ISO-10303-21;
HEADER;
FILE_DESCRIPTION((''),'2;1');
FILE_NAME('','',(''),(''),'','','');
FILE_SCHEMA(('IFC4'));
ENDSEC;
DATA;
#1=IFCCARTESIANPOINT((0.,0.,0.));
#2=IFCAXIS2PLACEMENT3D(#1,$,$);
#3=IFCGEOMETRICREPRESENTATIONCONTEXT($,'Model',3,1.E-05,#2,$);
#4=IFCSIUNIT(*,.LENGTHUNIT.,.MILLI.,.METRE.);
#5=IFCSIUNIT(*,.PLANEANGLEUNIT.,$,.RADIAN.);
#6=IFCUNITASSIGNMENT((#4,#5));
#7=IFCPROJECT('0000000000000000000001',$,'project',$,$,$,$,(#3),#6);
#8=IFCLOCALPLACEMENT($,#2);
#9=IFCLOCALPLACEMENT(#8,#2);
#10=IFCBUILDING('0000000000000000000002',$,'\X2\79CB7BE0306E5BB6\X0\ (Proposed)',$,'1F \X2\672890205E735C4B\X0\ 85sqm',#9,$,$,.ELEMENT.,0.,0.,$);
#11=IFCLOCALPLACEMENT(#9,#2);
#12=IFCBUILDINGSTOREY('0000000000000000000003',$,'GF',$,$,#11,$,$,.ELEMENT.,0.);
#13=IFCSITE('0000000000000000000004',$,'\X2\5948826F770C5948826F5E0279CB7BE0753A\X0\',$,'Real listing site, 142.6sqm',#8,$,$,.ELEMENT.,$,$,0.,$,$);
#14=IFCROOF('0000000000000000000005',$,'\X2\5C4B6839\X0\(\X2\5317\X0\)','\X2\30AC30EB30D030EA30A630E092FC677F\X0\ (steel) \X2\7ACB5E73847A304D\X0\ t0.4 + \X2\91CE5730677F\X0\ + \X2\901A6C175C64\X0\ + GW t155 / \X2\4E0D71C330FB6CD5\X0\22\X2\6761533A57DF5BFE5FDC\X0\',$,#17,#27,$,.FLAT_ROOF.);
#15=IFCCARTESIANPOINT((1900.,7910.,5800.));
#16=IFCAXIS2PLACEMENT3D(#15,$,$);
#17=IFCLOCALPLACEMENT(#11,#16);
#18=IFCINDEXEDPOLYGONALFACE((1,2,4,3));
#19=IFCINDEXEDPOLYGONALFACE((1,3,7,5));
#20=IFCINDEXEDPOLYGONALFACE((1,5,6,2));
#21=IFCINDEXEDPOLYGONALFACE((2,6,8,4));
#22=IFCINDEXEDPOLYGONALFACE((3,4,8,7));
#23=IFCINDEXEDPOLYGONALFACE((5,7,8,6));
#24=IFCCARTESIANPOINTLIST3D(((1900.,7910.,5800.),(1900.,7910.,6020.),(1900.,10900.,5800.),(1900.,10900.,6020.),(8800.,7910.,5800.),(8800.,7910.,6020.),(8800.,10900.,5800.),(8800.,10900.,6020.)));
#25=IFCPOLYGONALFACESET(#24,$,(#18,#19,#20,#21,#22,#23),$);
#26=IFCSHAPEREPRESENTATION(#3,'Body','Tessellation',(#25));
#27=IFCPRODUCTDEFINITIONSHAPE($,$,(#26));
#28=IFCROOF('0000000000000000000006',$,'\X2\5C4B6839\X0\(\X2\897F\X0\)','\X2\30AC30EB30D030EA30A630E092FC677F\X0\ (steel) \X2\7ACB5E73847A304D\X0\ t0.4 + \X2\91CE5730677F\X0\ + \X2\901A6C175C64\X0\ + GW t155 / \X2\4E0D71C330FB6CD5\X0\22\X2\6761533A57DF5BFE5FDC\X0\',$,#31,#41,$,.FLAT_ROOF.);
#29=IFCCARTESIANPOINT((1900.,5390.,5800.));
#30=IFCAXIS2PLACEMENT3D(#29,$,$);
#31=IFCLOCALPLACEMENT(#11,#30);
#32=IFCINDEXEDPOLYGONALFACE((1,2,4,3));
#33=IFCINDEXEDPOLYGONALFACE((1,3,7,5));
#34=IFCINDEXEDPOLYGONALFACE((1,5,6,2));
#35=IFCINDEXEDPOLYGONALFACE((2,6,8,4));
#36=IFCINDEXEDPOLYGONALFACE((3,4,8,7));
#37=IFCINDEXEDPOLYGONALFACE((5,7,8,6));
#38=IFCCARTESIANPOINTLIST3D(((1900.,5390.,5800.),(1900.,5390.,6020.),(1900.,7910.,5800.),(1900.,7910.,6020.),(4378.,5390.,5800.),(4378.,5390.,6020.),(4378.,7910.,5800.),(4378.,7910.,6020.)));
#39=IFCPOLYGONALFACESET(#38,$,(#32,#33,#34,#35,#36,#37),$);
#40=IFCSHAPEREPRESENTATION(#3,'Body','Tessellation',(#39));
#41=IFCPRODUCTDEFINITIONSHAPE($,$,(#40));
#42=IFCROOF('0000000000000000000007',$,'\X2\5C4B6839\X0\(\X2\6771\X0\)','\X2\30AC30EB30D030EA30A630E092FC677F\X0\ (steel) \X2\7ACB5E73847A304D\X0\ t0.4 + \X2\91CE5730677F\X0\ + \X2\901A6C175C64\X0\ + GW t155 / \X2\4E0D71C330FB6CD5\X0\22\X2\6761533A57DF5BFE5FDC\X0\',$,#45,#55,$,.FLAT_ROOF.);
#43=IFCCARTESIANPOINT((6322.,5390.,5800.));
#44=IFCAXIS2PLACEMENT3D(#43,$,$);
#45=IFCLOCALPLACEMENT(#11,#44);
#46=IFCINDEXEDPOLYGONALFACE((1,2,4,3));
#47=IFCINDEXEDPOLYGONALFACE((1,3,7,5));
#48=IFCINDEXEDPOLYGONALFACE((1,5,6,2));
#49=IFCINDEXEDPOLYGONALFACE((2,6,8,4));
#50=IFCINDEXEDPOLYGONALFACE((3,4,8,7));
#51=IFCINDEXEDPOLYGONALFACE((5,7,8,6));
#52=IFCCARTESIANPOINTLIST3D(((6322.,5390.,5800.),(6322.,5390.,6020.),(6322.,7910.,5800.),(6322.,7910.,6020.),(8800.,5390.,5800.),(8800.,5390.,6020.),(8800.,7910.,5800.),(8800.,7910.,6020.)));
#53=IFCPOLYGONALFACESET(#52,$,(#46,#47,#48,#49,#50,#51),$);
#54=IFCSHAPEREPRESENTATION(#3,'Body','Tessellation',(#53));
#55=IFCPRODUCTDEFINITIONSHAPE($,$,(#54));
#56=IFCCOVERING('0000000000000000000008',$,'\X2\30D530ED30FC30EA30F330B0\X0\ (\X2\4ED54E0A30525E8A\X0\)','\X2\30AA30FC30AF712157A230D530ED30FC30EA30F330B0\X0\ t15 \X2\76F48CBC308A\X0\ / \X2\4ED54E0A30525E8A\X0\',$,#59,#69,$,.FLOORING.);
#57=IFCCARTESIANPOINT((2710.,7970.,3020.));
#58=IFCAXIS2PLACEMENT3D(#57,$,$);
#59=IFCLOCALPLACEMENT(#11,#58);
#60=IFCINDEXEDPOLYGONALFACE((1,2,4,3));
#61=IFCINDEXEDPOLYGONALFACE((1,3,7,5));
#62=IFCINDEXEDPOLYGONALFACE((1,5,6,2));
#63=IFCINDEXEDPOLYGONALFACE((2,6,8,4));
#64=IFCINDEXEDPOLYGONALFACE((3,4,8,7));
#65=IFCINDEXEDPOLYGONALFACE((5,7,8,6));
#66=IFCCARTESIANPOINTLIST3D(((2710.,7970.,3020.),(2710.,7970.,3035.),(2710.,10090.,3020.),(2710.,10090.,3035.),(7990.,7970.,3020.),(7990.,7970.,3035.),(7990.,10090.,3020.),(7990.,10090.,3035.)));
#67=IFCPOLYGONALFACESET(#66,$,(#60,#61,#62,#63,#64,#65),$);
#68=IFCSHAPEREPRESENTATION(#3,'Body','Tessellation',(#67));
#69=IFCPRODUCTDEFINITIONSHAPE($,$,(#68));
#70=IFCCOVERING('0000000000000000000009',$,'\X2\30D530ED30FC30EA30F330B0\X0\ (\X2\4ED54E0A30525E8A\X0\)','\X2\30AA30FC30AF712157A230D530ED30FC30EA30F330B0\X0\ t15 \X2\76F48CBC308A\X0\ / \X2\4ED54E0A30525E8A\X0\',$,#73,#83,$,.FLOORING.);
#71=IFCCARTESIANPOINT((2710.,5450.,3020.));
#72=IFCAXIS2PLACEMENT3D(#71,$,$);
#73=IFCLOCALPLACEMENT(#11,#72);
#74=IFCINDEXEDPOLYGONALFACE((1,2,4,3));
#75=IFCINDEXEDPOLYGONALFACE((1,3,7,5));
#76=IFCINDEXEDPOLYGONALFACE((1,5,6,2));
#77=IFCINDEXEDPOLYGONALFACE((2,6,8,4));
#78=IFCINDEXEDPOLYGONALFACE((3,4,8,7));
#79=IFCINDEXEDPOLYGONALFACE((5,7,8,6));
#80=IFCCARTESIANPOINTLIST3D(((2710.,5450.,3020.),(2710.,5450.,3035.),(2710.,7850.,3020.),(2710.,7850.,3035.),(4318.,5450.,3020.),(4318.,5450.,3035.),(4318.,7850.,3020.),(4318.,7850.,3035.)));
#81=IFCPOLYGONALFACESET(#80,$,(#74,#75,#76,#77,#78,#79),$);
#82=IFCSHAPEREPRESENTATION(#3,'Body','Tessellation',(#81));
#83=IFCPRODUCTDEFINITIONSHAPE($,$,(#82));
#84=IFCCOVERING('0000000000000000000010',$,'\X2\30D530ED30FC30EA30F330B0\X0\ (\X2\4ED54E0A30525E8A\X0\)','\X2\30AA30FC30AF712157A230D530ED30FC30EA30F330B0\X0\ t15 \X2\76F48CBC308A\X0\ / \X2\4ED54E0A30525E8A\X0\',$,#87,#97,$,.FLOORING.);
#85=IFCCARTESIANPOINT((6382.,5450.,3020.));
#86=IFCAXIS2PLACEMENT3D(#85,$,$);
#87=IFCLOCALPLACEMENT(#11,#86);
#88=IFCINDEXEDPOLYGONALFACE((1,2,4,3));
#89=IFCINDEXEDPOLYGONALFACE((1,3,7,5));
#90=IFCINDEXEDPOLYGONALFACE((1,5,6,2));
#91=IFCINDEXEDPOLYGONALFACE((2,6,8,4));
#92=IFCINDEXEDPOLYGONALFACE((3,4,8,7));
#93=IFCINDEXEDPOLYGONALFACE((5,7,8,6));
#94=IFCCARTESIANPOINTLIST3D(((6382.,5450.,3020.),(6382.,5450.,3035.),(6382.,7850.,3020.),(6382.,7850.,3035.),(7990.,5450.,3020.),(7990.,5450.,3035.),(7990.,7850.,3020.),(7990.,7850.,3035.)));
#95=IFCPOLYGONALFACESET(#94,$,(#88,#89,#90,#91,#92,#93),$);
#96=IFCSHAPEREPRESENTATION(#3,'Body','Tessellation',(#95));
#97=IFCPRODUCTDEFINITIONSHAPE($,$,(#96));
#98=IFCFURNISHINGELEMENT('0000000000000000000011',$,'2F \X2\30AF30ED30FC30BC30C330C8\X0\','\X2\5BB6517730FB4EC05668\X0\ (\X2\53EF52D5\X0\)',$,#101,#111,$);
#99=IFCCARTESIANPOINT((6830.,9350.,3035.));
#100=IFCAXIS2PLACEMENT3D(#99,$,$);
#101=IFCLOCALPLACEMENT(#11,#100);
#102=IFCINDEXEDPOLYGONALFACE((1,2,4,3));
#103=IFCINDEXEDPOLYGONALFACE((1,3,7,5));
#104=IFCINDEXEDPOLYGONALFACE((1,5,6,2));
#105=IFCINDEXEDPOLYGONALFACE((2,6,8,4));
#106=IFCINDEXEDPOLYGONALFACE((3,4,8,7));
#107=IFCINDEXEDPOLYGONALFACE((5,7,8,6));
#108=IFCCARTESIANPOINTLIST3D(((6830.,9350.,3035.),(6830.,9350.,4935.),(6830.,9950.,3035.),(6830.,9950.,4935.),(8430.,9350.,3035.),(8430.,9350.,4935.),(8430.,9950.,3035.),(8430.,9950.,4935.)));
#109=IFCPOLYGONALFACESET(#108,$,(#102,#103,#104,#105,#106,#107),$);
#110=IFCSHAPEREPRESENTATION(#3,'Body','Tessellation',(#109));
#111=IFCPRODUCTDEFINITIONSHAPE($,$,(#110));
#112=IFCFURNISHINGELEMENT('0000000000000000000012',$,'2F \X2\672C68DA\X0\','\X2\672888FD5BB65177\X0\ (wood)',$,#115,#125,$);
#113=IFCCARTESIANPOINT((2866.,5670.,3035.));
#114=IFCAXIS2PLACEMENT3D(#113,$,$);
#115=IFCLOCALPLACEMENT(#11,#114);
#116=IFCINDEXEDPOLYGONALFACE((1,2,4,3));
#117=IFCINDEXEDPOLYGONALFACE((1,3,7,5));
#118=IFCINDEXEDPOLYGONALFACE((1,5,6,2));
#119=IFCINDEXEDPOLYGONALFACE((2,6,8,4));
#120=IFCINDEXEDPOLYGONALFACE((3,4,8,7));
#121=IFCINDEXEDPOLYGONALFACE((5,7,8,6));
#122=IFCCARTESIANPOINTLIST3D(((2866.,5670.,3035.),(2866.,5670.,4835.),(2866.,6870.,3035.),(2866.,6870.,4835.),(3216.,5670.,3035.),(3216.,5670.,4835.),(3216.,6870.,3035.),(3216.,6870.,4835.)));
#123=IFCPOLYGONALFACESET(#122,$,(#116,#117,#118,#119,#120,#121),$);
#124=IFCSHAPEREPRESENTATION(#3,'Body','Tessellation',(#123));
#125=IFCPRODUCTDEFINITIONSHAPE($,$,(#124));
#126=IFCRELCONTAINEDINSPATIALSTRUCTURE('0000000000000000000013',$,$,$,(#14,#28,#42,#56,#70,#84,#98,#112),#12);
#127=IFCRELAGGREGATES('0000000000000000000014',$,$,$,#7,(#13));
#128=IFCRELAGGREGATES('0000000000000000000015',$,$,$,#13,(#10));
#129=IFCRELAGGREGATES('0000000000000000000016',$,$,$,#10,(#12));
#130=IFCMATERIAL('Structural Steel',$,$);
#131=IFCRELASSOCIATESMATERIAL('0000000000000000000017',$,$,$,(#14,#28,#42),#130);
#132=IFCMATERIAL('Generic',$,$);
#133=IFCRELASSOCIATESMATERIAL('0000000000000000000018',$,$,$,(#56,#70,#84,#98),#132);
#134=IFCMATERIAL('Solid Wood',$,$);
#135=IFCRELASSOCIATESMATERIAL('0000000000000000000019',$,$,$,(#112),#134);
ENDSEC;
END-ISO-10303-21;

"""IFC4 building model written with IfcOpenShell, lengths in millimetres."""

from ifc_helpers import new_model, si_unit, frame, frame_2d, origin, place, context, project, spatial, rectangle, extrude, material, element, save


model = new_model("IFC4")

# Units and contexts
model_context = context("Model", 3, precision=1e-05, world=origin())
ifc_project = project(units=[si_unit("LENGTHUNIT", "METRE", prefix="MILLI"), si_unit("PLANEANGLEUNIT", "RADIAN")], contexts=[model_context])

# Site, building, storey
site_placement = place(None, origin())
site = spatial("IfcSite", under=ifc_project, at=site_placement, Name="奈良県奈良市秋篠町", ObjectType="Real listing site, 142.6sqm", CompositionType="ELEMENT", RefElevation=0.0)
building_placement = place(site_placement, origin())
building = spatial("IfcBuilding", under=site, at=building_placement, Name="秋篠の家 (Proposed)", ObjectType="1F 木造平屋 85sqm", CompositionType="ELEMENT", ElevationOfRefHeight=0.0, ElevationOfTerrain=0.0)
storey_placement = place(building_placement, origin())
storey = spatial("IfcBuildingStorey", under=building, at=storey_placement, Name="GF", CompositionType="ELEMENT", Elevation=0.0)

# Shared definitions
ifc_material_1 = material(Name="Solid Wood")

# Shared definitions
ifc_material_2 = material(Name="Generic")

# Roofs
ifc_material_3 = material(Name="Structural Steel")
for number, where, name in (
    (1, (1900.0, 7910.0, 5800.0), "屋根(北)"),
):
    element("IfcRoof", number, at=place(storey_placement, frame(where)), inside=storey, material=ifc_material_3, Name=name, Description="ガルバリウム鋼板 (steel) 立平葺き t0.4 + 野地板 + 通気層 + GW t155 / 不燃・法22条区域対応", PredefinedType="FLAT_ROOF", context=model_context, shape_type="SweptSolid", body=[
        extrude(rectangle(XDim=6900.0, YDim=2990.0, at=frame_2d((3450.0, 1495.0))), frame((1900.0, 7910.0, 5800.0)), (0.0, 0.0, 1.0), 220.0),
    ])
roof_1_placement = place(storey_placement, frame((1900.0, 5390.0, 5800.0)))
element("IfcRoof", 2, at=roof_1_placement, inside=storey, material=ifc_material_3, Name="屋根(西)", Description="ガルバリウム鋼板 (steel) 立平葺き t0.4 + 野地板 + 通気層 + GW t155 / 不燃・法22条区域対応", PredefinedType="FLAT_ROOF", context=model_context, shape_type="SweptSolid", body=[
    extrude(rectangle(XDim=2478.0, YDim=2520.0, at=frame_2d((1239.0, 1260.0))), frame((1900.0, 5390.0, 5800.0)), (0.0, 0.0, 1.0), 220.0),
])
roof_2_placement = place(storey_placement, frame((6322.0, 5390.0, 5800.0)))
element("IfcRoof", 3, at=roof_2_placement, inside=storey, material=ifc_material_3, Name="屋根(東)", Description="ガルバリウム鋼板 (steel) 立平葺き t0.4 + 野地板 + 通気層 + GW t155 / 不燃・法22条区域対応", PredefinedType="FLAT_ROOF", context=model_context, shape_type="SweptSolid", body=[
    extrude(rectangle(XDim=2478.0, YDim=2520.0, at=frame_2d((1239.0, 1260.0))), frame((6322.0, 5390.0, 5800.0)), (0.0, 0.0, 1.0), 220.0),
])

# Coverings
covering_1_placement = place(storey_placement, frame((2710.0, 7970.0, 3020.0)))
element("IfcCovering", 4, at=covering_1_placement, inside=storey, material=ifc_material_2, Name="フローリング (仕上げ床)", Description="オーク無垢フローリング t15 直貼り / 仕上げ床", PredefinedType="FLOORING", context=model_context, shape_type="SweptSolid", body=[
    extrude(rectangle(XDim=5280.0, YDim=2120.0, at=frame_2d((2640.0, 1060.0))), frame((2710.0, 7970.0, 3020.0)), (0.0, 0.0, 1.0), 15.0),
])
covering_2_placement = place(storey_placement, frame((2710.0, 5450.0, 3020.0)))
element("IfcCovering", 5, at=covering_2_placement, inside=storey, material=ifc_material_2, Name="フローリング (仕上げ床)", Description="オーク無垢フローリング t15 直貼り / 仕上げ床", PredefinedType="FLOORING", context=model_context, shape_type="SweptSolid", body=[
    extrude(rectangle(XDim=1608.0, YDim=2400.0, at=frame_2d((804.0, 1200.0))), frame((2710.0, 5450.0, 3020.0)), (0.0, 0.0, 1.0), 15.0),
])
covering_3_placement = place(storey_placement, frame((6382.0, 5450.0, 3020.0)))
element("IfcCovering", 6, at=covering_3_placement, inside=storey, material=ifc_material_2, Name="フローリング (仕上げ床)", Description="オーク無垢フローリング t15 直貼り / 仕上げ床", PredefinedType="FLOORING", context=model_context, shape_type="SweptSolid", body=[
    extrude(rectangle(XDim=1608.0, YDim=2400.0, at=frame_2d((804.0, 1200.0))), frame((6382.0, 5450.0, 3020.0)), (0.0, 0.0, 1.0), 15.0),
])

# Furnishing elements
furnishing_1_placement = place(storey_placement, frame((6830.0, 9350.0, 3035.0)))
element("IfcFurnishingElement", 7, at=furnishing_1_placement, inside=storey, material=ifc_material_2, Name="2F クローゼット", Description="家具・什器 (可動)", context=model_context, shape_type="SweptSolid", body=[
    extrude(rectangle(XDim=1600.0, YDim=600.0, at=frame_2d((800.0, 300.0))), frame((6830.0, 9350.0, 3035.0)), (0.0, 0.0, 1.0), 1900.0),
])
furnishing_2_placement = place(storey_placement, frame((2866.0, 5670.0, 3035.0)))
element("IfcFurnishingElement", 8, at=furnishing_2_placement, inside=storey, material=ifc_material_1, Name="2F 本棚", Description="木製家具 (wood)", context=model_context, shape_type="SweptSolid", body=[
    extrude(rectangle(XDim=350.0, YDim=1200.0, at=frame_2d((175.0, 600.0))), frame((2866.0, 5670.0, 3035.0)), (0.0, 0.0, 1.0), 1800.0),
])

save(model, "model.ifc")
